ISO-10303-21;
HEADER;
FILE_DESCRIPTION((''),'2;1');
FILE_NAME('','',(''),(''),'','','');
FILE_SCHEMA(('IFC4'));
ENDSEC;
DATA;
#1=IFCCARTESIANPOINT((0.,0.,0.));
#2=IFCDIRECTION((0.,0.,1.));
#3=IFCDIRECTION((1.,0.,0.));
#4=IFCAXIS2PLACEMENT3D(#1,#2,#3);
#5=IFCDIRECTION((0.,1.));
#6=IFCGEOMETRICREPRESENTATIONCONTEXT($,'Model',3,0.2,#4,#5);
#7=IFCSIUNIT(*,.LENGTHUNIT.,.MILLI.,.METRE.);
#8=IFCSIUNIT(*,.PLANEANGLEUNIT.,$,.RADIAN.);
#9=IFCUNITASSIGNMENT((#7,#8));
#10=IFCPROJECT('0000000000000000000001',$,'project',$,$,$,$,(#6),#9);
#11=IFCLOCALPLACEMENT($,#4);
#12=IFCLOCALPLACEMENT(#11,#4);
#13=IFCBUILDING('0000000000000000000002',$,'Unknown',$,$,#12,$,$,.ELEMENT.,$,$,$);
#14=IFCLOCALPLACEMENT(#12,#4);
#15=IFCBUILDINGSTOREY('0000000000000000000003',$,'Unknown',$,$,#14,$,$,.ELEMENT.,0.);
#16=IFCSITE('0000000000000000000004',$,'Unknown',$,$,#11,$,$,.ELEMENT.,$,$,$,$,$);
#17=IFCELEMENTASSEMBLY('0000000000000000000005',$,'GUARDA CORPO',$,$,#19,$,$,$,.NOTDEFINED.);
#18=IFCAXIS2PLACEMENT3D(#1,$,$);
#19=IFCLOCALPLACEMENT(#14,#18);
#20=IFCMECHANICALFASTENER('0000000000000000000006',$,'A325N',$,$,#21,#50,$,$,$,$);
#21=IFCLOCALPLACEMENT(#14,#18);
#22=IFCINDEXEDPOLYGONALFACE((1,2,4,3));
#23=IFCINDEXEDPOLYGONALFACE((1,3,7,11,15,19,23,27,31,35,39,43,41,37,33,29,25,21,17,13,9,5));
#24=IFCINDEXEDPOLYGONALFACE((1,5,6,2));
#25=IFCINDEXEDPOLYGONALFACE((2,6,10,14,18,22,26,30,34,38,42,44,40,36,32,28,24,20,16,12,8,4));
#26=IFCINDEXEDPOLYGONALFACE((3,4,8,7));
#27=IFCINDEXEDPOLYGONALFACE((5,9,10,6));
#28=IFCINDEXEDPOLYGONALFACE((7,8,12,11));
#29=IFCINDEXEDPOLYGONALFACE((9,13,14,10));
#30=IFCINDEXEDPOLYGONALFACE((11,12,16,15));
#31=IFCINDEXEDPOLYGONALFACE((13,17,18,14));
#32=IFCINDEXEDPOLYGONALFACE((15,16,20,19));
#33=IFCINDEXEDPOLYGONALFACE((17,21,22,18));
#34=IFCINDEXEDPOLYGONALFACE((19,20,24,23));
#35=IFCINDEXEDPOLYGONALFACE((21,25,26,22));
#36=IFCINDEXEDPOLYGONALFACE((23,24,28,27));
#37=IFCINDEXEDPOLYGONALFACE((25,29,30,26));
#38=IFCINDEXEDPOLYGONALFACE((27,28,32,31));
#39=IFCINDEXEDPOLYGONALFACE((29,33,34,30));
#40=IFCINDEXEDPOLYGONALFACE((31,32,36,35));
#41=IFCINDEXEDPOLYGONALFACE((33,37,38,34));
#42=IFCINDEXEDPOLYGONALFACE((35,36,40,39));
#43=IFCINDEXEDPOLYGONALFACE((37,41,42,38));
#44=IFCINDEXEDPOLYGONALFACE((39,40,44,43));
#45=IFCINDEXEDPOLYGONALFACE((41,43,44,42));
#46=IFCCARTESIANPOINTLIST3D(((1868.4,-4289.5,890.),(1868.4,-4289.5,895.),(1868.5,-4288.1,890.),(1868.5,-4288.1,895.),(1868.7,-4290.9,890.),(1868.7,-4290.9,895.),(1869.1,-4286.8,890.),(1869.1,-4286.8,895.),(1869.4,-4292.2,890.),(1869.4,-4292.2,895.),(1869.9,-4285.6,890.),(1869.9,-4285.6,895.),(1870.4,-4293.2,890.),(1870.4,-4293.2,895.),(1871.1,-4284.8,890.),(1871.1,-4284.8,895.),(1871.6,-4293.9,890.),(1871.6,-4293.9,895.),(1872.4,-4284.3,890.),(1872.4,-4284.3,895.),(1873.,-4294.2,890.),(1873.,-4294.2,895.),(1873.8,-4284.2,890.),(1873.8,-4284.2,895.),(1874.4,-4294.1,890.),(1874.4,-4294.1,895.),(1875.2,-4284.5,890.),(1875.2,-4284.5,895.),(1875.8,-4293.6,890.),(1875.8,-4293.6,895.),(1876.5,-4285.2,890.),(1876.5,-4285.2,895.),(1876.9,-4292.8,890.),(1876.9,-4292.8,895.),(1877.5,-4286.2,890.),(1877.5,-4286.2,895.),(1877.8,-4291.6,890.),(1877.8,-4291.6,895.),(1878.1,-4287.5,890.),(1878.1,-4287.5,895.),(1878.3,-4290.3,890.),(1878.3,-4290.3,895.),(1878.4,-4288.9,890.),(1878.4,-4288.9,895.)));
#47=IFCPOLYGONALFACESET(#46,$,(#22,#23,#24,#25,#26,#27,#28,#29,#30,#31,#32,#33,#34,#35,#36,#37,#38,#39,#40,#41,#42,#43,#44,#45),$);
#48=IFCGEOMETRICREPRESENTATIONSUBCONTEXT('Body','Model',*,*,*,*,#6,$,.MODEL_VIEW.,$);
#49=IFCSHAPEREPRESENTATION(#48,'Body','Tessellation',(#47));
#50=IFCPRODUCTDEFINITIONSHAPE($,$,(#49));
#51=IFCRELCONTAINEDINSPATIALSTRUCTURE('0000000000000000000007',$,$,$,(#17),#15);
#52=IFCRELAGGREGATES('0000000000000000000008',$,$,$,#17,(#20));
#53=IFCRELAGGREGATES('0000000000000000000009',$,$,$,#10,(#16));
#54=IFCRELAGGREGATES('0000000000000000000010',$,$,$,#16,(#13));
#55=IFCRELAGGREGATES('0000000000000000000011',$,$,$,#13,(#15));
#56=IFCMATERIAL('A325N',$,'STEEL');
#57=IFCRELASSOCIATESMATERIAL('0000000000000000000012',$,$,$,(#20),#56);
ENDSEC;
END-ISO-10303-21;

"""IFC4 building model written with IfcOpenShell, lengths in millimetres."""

from ifc_helpers import new_model, si_unit, direction, frame, origin_with_axes, place, context, subcontext, project, spatial, arc, indexed_curve, outline, extrude, source, transform, mapped, material, element, aggregate, save


model = new_model("IFC4")

# Units and contexts
model_context = context("Model", 3, precision=0.2, world=origin_with_axes(), true_north=direction((0.0, 1.0)))
body_context = subcontext(model_context, "Body", "Model", "MODEL_VIEW")
ifc_project = project(units=[si_unit("LENGTHUNIT", "METRE", prefix="MILLI"), si_unit("PLANEANGLEUNIT", "RADIAN")], contexts=[model_context])

# Site, building, storey
site_placement = place(None, origin_with_axes())
site = spatial("IfcSite", under=ifc_project, at=site_placement, Name="Unknown", CompositionType="ELEMENT")
building_placement = place(site_placement, origin_with_axes())
building = spatial("IfcBuilding", under=site, at=building_placement, Name="Unknown", CompositionType="ELEMENT")
storey_placement = place(building_placement, origin_with_axes())
storey = spatial("IfcBuildingStorey", under=building, at=storey_placement, Name="Unknown", CompositionType="ELEMENT", Elevation=0.0)

# Element assembly
assembly_1_placement = place(storey_placement, frame((833.2, -4289.3, 1615.0), z_axis=(-0.000512, 1.0, -0.000003), x_axis=(0.000003, 0.000003, 1.0)))
assembly_1 = element("IfcElementAssembly", 1, at=assembly_1_placement, inside=storey, Name="GUARDA CORPO", PredefinedType="NOTDEFINED")

# Shared definitions
ifc_material_1 = material(Name="A325N", Category="STEEL")

# Mechanical fastener
shared_shape_1 = source(origin_with_axes(), body_context, "Body", "SweptSolid", [
    extrude(outline(indexed_curve([(5.0, 0.0), (0.0, 5.0), (-5.0, 0.0), (0.0, -5.0)], segments=[arc(1, 2, 3), arc(3, 4, 1)])), frame((0.0, 0.0, 0.0), z_axis=(0.0, 0.0, -1.0), x_axis=(0.0, 1.0, 0.0)), (0.0, 0.0, 1.0), 5.0),
])
mechanical_fastener_1_placement = place(assembly_1_placement, frame((-720.0, 1040.2, -0.5), z_axis=(1.0, -0.000004, -0.000003), x_axis=(0.000005, 0.882404, 0.470493)))
mechanical_fastener_1 = element("IfcMechanicalFastener", 2, at=mechanical_fastener_1_placement, material=ifc_material_1, Name="A325N", context=body_context, shape_type="MappedRepresentation", body=[
    mapped(shared_shape_1, transform((0.0, 0.0, 0.0))),
])
aggregate(assembly_1, [mechanical_fastener_1])

save(model, "model.ifc")
